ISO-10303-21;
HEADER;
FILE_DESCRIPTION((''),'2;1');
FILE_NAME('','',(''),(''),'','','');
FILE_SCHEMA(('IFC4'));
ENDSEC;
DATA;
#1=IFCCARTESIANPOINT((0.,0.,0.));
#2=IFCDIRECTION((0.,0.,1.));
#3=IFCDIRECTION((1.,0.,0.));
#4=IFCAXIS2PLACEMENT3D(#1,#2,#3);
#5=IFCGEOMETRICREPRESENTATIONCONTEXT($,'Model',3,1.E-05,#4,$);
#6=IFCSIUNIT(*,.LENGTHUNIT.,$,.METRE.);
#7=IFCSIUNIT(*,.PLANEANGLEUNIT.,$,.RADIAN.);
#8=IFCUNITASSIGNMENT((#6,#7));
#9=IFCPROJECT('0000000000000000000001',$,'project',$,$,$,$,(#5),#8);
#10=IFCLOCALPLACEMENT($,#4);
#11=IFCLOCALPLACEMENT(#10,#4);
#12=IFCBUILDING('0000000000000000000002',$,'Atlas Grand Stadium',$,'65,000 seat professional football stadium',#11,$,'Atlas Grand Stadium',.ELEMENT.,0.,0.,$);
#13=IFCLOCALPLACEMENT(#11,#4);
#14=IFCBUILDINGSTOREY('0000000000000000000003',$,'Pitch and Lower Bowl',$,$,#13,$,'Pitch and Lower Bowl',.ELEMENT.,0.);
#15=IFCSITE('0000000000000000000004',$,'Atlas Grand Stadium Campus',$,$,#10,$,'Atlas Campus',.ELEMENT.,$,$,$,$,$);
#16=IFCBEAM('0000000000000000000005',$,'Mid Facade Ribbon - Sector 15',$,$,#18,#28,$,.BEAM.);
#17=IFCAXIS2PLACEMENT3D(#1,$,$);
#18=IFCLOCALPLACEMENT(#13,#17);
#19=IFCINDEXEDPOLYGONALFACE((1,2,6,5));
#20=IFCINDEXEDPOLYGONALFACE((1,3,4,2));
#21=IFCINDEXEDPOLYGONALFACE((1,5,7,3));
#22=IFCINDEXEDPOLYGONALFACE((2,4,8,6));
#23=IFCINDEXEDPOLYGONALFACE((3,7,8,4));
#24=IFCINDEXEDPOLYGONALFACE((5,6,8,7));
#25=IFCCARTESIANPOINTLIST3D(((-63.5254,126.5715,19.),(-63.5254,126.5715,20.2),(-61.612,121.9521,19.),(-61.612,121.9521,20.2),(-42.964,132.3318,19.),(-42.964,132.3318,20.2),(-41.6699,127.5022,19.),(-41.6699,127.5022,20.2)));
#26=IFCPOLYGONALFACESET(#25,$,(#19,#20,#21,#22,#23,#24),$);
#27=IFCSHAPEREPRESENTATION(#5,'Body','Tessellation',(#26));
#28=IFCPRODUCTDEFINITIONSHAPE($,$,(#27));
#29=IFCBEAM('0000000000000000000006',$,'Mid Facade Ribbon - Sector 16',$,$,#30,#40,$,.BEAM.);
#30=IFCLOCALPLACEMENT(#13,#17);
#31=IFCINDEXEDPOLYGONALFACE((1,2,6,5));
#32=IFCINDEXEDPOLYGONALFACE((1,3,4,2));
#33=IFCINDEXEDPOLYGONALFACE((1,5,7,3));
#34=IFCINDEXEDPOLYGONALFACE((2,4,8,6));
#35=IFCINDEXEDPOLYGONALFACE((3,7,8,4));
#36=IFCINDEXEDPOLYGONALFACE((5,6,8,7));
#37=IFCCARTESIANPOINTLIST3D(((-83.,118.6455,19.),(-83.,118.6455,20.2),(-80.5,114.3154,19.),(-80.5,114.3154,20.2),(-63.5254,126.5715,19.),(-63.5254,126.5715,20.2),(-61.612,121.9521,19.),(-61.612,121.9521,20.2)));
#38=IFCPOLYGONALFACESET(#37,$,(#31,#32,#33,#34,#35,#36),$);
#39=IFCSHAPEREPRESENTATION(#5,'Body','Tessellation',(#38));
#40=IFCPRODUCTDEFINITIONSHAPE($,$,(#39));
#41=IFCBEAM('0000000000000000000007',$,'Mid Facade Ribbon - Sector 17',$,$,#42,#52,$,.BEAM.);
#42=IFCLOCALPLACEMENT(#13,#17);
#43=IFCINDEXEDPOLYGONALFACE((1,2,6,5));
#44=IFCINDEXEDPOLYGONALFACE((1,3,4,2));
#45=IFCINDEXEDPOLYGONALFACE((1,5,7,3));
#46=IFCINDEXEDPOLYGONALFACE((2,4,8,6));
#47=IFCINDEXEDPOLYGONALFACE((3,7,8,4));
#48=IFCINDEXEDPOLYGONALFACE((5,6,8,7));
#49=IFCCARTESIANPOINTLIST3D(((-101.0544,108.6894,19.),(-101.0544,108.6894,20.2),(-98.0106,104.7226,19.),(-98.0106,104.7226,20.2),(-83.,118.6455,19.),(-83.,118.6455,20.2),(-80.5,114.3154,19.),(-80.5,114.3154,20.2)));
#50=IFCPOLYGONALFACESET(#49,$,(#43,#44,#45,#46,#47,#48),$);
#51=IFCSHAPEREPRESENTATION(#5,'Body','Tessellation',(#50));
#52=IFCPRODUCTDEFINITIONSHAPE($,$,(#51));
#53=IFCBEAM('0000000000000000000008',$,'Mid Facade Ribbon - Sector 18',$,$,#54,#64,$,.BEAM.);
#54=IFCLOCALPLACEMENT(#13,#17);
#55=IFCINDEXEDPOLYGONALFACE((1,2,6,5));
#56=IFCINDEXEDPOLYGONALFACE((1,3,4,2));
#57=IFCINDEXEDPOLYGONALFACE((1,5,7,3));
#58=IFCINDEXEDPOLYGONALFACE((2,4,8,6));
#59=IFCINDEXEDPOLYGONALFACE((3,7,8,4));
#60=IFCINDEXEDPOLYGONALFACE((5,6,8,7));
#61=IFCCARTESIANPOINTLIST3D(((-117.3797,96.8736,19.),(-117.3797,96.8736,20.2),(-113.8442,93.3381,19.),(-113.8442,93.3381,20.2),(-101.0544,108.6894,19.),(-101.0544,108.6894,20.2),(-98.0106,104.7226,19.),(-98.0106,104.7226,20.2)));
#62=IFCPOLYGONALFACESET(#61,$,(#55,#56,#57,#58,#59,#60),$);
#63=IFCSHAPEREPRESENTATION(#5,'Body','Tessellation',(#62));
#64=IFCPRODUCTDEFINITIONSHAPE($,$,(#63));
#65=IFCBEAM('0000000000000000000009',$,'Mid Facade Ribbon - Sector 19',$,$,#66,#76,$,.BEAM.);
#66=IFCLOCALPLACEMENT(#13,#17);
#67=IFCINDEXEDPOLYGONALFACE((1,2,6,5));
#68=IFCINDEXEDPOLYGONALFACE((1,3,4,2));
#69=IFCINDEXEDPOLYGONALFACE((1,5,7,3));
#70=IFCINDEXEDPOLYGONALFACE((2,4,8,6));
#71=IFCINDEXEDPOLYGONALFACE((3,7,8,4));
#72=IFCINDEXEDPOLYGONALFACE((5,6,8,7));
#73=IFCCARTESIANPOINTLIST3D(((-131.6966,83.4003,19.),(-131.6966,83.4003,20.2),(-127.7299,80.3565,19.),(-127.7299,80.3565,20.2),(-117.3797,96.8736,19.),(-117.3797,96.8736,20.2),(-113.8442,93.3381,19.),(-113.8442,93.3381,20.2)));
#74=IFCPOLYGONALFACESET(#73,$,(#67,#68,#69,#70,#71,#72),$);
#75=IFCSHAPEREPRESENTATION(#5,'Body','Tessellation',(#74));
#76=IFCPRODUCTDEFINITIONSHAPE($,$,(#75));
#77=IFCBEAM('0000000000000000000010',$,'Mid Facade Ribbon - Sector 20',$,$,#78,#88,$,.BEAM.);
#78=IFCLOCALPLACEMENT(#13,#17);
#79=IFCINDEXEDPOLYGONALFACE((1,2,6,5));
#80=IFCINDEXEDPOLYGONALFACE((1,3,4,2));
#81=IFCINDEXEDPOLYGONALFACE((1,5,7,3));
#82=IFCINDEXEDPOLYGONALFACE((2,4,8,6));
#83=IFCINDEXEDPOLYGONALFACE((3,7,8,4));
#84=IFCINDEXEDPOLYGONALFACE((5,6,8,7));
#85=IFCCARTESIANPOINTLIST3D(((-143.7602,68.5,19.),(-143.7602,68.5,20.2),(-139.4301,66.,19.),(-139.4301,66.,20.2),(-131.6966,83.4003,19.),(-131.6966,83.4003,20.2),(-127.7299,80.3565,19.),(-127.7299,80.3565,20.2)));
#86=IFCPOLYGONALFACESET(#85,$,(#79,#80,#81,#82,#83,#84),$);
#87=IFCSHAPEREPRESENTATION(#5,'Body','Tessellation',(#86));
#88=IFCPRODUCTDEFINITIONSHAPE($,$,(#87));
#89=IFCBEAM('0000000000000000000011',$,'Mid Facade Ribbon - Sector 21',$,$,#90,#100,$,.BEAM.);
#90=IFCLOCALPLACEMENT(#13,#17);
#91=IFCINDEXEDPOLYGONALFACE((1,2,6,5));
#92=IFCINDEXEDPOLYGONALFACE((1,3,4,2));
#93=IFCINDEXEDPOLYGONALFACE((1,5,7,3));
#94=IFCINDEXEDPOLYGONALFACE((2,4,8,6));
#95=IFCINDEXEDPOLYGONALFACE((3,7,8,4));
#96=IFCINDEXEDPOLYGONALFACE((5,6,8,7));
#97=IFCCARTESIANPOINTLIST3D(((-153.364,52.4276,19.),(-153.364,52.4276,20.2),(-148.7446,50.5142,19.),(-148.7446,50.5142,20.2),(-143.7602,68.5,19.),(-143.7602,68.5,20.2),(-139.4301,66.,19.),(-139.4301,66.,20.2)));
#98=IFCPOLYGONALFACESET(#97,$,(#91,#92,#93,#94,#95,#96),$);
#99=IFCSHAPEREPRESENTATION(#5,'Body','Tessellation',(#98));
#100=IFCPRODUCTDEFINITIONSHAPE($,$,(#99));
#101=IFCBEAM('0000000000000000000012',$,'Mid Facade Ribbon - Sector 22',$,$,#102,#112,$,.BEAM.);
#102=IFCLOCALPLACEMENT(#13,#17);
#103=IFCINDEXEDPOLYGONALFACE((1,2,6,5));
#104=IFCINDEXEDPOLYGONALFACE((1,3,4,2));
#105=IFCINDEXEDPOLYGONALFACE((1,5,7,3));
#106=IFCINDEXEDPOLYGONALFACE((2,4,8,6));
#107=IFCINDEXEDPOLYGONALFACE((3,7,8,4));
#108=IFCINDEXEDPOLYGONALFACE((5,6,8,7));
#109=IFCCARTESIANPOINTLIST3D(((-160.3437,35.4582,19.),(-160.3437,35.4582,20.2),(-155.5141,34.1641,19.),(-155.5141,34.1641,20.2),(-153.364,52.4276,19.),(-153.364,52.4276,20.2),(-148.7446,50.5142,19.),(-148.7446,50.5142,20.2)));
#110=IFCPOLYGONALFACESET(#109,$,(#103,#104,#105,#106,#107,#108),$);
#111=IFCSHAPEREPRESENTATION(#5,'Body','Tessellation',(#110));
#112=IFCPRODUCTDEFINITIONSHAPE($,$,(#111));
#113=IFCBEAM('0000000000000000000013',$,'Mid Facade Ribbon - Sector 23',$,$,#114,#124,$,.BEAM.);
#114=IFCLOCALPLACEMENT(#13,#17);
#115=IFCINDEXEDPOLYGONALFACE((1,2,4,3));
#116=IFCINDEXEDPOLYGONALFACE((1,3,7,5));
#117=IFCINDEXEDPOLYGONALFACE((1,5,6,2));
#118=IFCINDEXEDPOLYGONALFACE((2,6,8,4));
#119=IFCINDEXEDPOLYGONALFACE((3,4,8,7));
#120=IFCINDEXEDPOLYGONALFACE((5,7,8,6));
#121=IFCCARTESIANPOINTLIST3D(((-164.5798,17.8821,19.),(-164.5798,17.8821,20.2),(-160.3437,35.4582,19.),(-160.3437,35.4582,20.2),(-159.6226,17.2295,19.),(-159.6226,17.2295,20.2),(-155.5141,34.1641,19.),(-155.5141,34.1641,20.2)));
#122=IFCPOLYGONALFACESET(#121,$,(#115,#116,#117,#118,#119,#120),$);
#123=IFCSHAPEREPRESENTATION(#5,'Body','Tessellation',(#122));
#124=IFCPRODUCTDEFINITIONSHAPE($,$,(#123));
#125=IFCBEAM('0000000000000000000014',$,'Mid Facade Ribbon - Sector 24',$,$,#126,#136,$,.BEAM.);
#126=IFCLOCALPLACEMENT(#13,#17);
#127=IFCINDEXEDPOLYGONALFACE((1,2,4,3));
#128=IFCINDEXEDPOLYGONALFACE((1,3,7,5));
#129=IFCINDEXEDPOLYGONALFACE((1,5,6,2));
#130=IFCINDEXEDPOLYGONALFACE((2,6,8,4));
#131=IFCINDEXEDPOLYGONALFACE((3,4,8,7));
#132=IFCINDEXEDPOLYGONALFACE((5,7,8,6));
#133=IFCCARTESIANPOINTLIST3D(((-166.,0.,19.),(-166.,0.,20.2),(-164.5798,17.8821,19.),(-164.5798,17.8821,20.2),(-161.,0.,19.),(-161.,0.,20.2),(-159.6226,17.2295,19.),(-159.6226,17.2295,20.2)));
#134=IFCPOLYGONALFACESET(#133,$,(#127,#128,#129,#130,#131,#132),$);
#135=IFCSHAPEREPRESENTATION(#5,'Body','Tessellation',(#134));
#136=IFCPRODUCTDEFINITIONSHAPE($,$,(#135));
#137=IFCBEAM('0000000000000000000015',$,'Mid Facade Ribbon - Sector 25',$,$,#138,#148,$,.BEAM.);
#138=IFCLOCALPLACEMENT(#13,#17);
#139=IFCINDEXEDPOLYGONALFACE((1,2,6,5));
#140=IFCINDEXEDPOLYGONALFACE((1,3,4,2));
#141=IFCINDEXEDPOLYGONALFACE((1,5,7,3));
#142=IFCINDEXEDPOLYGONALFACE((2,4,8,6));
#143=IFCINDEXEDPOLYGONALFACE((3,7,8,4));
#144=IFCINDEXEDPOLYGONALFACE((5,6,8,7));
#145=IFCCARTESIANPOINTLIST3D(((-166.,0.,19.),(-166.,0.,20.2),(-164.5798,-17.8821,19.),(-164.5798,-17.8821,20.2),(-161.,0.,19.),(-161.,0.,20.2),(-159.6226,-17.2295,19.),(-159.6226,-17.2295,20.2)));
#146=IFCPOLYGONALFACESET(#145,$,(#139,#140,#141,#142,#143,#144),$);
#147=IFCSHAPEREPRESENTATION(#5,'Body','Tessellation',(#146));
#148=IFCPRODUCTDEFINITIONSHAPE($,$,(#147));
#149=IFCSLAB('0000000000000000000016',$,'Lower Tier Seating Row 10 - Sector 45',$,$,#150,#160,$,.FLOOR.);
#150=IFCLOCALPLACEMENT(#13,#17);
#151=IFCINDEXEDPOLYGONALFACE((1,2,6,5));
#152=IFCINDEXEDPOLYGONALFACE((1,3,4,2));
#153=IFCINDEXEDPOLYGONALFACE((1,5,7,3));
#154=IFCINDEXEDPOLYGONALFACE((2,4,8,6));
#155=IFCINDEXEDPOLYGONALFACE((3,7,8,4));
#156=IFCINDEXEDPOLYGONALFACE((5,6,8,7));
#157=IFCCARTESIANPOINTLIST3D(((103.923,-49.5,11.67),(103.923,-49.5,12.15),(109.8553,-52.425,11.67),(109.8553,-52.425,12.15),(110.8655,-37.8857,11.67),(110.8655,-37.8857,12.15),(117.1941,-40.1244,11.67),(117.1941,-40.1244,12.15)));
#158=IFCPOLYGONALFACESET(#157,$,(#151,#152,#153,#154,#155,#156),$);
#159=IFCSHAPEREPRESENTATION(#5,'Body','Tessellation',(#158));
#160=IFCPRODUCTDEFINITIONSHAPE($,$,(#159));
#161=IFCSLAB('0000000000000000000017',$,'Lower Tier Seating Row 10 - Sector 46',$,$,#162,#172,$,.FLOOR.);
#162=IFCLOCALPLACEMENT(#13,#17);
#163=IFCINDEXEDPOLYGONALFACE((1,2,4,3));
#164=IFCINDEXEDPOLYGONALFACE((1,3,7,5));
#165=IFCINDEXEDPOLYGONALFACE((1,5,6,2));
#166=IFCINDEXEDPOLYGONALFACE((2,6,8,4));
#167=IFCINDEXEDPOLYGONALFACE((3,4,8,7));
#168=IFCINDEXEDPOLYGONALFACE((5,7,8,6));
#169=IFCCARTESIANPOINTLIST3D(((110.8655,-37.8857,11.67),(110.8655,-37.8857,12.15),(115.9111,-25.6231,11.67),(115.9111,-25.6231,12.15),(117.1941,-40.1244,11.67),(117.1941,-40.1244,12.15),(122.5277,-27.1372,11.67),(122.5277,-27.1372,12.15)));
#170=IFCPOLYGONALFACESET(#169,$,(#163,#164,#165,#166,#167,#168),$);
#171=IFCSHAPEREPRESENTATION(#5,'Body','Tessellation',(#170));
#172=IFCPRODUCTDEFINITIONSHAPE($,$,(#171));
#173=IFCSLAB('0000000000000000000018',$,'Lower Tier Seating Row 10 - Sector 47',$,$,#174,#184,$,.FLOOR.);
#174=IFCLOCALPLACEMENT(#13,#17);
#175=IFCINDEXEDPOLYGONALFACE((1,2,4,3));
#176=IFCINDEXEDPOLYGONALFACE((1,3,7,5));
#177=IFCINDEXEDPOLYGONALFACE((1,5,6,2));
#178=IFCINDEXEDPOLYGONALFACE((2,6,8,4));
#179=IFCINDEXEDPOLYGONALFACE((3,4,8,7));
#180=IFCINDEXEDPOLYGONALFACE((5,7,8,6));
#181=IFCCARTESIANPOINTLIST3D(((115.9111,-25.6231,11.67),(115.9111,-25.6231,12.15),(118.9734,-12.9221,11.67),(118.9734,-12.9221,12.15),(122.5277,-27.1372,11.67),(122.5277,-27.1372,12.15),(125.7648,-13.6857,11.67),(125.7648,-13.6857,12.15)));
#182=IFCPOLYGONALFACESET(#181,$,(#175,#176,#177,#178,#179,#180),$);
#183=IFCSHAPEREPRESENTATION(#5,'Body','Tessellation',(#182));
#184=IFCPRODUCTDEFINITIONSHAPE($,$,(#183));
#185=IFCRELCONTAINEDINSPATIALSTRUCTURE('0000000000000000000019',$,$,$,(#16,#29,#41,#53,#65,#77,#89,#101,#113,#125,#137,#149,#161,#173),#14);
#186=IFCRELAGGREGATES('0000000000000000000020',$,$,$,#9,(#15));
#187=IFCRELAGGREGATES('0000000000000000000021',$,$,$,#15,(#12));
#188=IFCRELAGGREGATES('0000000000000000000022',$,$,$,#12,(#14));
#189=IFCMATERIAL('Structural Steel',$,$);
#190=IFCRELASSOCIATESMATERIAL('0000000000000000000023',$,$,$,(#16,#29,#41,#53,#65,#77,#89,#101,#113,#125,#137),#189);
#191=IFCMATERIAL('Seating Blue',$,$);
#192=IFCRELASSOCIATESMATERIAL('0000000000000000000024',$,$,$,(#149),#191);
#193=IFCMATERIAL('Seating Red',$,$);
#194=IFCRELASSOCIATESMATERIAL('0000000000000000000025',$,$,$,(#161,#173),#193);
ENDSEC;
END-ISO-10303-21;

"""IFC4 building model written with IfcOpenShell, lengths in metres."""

from ifc_helpers import new_model, si_unit, frame, origin_with_axes, place, context, project, spatial, polyline, outline, extrude, material, element, save


model = new_model("IFC4")

# Units and contexts
model_context = context("Model", 3, precision=1e-05, world=origin_with_axes())
ifc_project = project(units=[si_unit("LENGTHUNIT", "METRE"), si_unit("PLANEANGLEUNIT", "RADIAN")], contexts=[model_context])

# Site, building, storey
site_placement = place(None, origin_with_axes())
site = spatial("IfcSite", under=ifc_project, at=site_placement, Name="Atlas Grand Stadium Campus", LongName="Atlas Campus", CompositionType="ELEMENT")
building_placement = place(site_placement, origin_with_axes())
building = spatial("IfcBuilding", under=site, at=building_placement, Name="Atlas Grand Stadium", ObjectType="65,000 seat professional football stadium", LongName="Atlas Grand Stadium", CompositionType="ELEMENT", ElevationOfRefHeight=0.0, ElevationOfTerrain=0.0)
storey_placement = place(building_placement, origin_with_axes())
storey = spatial("IfcBuildingStorey", under=building, at=storey_placement, Name="Pitch and Lower Bowl", LongName="Pitch and Lower Bowl", CompositionType="ELEMENT", Elevation=0.0)

# Beams
ifc_material_1 = material(Name="Structural Steel")
beam_1_placement = place(storey_placement, frame((0.0, 0.0, 19.0), z_axis=(0.0, 0.0, 1.0), x_axis=(1.0, 0.0, 0.0)))
element("IfcBeam", 1, at=beam_1_placement, inside=storey, material=ifc_material_1, Name="Mid Facade Ribbon - Sector 15", PredefinedType="BEAM", context=model_context, shape_type="SweptSolid", body=[
    extrude(outline(polyline([(-42.964, 132.3318), (-63.5254, 126.5715), (-61.612, 121.9521), (-41.6699, 127.5022), (-42.964, 132.3318)])), origin_with_axes(), (0.0, 0.0, 1.0), 1.2),
])
beam_2_placement = place(storey_placement, frame((0.0, 0.0, 19.0), z_axis=(0.0, 0.0, 1.0), x_axis=(1.0, 0.0, 0.0)))
element("IfcBeam", 2, at=beam_2_placement, inside=storey, material=ifc_material_1, Name="Mid Facade Ribbon - Sector 16", PredefinedType="BEAM", context=model_context, shape_type="SweptSolid", body=[
    extrude(outline(polyline([(-63.5254, 126.5715), (-83.0, 118.6455), (-80.5, 114.3153), (-61.612, 121.9521), (-63.5254, 126.5715)])), origin_with_axes(), (0.0, 0.0, 1.0), 1.2),
])
beam_3_placement = place(storey_placement, frame((0.0, 0.0, 19.0), z_axis=(0.0, 0.0, 1.0), x_axis=(1.0, 0.0, 0.0)))
element("IfcBeam", 3, at=beam_3_placement, inside=storey, material=ifc_material_1, Name="Mid Facade Ribbon - Sector 17", PredefinedType="BEAM", context=model_context, shape_type="SweptSolid", body=[
    extrude(outline(polyline([(-83.0, 118.6455), (-101.0544, 108.6894), (-98.0106, 104.7226), (-80.5, 114.3153), (-83.0, 118.6455)])), origin_with_axes(), (0.0, 0.0, 1.0), 1.2),
])
beam_4_placement = place(storey_placement, frame((0.0, 0.0, 19.0), z_axis=(0.0, 0.0, 1.0), x_axis=(1.0, 0.0, 0.0)))
element("IfcBeam", 4, at=beam_4_placement, inside=storey, material=ifc_material_1, Name="Mid Facade Ribbon - Sector 18", PredefinedType="BEAM", context=model_context, shape_type="SweptSolid", body=[
    extrude(outline(polyline([(-101.0544, 108.6894), (-117.3797, 96.8736), (-113.8442, 93.3381), (-98.0106, 104.7226), (-101.0544, 108.6894)])), origin_with_axes(), (0.0, 0.0, 1.0), 1.2),
])
beam_5_placement = place(storey_placement, frame((0.0, 0.0, 19.0), z_axis=(0.0, 0.0, 1.0), x_axis=(1.0, 0.0, 0.0)))
element("IfcBeam", 5, at=beam_5_placement, inside=storey, material=ifc_material_1, Name="Mid Facade Ribbon - Sector 19", PredefinedType="BEAM", context=model_context, shape_type="SweptSolid", body=[
    extrude(outline(polyline([(-117.3797, 96.8736), (-131.6967, 83.4003), (-127.7299, 80.3565), (-113.8442, 93.3381), (-117.3797, 96.8736)])), origin_with_axes(), (0.0, 0.0, 1.0), 1.2),
])
beam_6_placement = place(storey_placement, frame((0.0, 0.0, 19.0), z_axis=(0.0, 0.0, 1.0), x_axis=(1.0, 0.0, 0.0)))
element("IfcBeam", 6, at=beam_6_placement, inside=storey, material=ifc_material_1, Name="Mid Facade Ribbon - Sector 20", PredefinedType="BEAM", context=model_context, shape_type="SweptSolid", body=[
    extrude(outline(polyline([(-131.6967, 83.4003), (-143.7602, 68.5), (-139.4301, 66.0), (-127.7299, 80.3565), (-131.6967, 83.4003)])), origin_with_axes(), (0.0, 0.0, 1.0), 1.2),
])
beam_7_placement = place(storey_placement, frame((0.0, 0.0, 19.0), z_axis=(0.0, 0.0, 1.0), x_axis=(1.0, 0.0, 0.0)))
element("IfcBeam", 7, at=beam_7_placement, inside=storey, material=ifc_material_1, Name="Mid Facade Ribbon - Sector 21", PredefinedType="BEAM", context=model_context, shape_type="SweptSolid", body=[
    extrude(outline(polyline([(-143.7602, 68.5), (-153.364, 52.4276), (-148.7446, 50.5142), (-139.4301, 66.0), (-143.7602, 68.5)])), origin_with_axes(), (0.0, 0.0, 1.0), 1.2),
])
beam_8_placement = place(storey_placement, frame((0.0, 0.0, 19.0), z_axis=(0.0, 0.0, 1.0), x_axis=(1.0, 0.0, 0.0)))
element("IfcBeam", 8, at=beam_8_placement, inside=storey, material=ifc_material_1, Name="Mid Facade Ribbon - Sector 22", PredefinedType="BEAM", context=model_context, shape_type="SweptSolid", body=[
    extrude(outline(polyline([(-153.364, 52.4276), (-160.3437, 35.4582), (-155.5141, 34.1641), (-148.7446, 50.5142), (-153.364, 52.4276)])), origin_with_axes(), (0.0, 0.0, 1.0), 1.2),
])
beam_9_placement = place(storey_placement, frame((0.0, 0.0, 19.0), z_axis=(0.0, 0.0, 1.0), x_axis=(1.0, 0.0, 0.0)))
element("IfcBeam", 9, at=beam_9_placement, inside=storey, material=ifc_material_1, Name="Mid Facade Ribbon - Sector 23", PredefinedType="BEAM", context=model_context, shape_type="SweptSolid", body=[
    extrude(outline(polyline([(-160.3437, 35.4582), (-164.5798, 17.8821), (-159.6226, 17.2295), (-155.5141, 34.1641), (-160.3437, 35.4582)])), origin_with_axes(), (0.0, 0.0, 1.0), 1.2),
])
beam_10_placement = place(storey_placement, frame((0.0, 0.0, 19.0), z_axis=(0.0, 0.0, 1.0), x_axis=(1.0, 0.0, 0.0)))
element("IfcBeam", 10, at=beam_10_placement, inside=storey, material=ifc_material_1, Name="Mid Facade Ribbon - Sector 24", PredefinedType="BEAM", context=model_context, shape_type="SweptSolid", body=[
    extrude(outline(polyline([(-164.5798, 17.8821), (-166.0, 0.0), (-161.0, 0.0), (-159.6226, 17.2295), (-164.5798, 17.8821)])), origin_with_axes(), (0.0, 0.0, 1.0), 1.2),
])
beam_11_placement = place(storey_placement, frame((0.0, 0.0, 19.0), z_axis=(0.0, 0.0, 1.0), x_axis=(1.0, 0.0, 0.0)))
element("IfcBeam", 11, at=beam_11_placement, inside=storey, material=ifc_material_1, Name="Mid Facade Ribbon - Sector 25", PredefinedType="BEAM", context=model_context, shape_type="SweptSolid", body=[
    extrude(outline(polyline([(-166.0, 0.0), (-164.5798, -17.8821), (-159.6226, -17.2295), (-161.0, 0.0), (-166.0, 0.0)])), origin_with_axes(), (0.0, 0.0, 1.0), 1.2),
])

# Slabs
ifc_material_2 = material(Name="Seating Blue")
slab_1_placement = place(storey_placement, frame((0.0, 0.0, 11.67), z_axis=(0.0, 0.0, 1.0), x_axis=(1.0, 0.0, 0.0)))
element("IfcSlab", 12, at=slab_1_placement, inside=storey, material=ifc_material_2, Name="Lower Tier Seating Row 10 - Sector 45", PredefinedType="FLOOR", context=model_context, shape_type="SweptSolid", body=[
    extrude(outline(polyline([(109.8553, -52.425), (117.1941, -40.1244), (110.8655, -37.8857), (103.9231, -49.5), (109.8553, -52.425)])), origin_with_axes(), (0.0, 0.0, 1.0), 0.48),
])
ifc_material_3 = material(Name="Seating Red")
slab_2_placement = place(storey_placement, frame((0.0, 0.0, 11.67), z_axis=(0.0, 0.0, 1.0), x_axis=(1.0, 0.0, 0.0)))
element("IfcSlab", 13, at=slab_2_placement, inside=storey, material=ifc_material_3, Name="Lower Tier Seating Row 10 - Sector 46", PredefinedType="FLOOR", context=model_context, shape_type="SweptSolid", body=[
    extrude(outline(polyline([(117.1941, -40.1244), (122.5277, -27.1372), (115.9111, -25.6231), (110.8655, -37.8857), (117.1941, -40.1244)])), origin_with_axes(), (0.0, 0.0, 1.0), 0.48),
])
slab_3_placement = place(storey_placement, frame((0.0, 0.0, 11.67), z_axis=(0.0, 0.0, 1.0), x_axis=(1.0, 0.0, 0.0)))
element("IfcSlab", 14, at=slab_3_placement, inside=storey, material=ifc_material_3, Name="Lower Tier Seating Row 10 - Sector 47", PredefinedType="FLOOR", context=model_context, shape_type="SweptSolid", body=[
    extrude(outline(polyline([(122.5277, -27.1372), (125.7648, -13.6857), (118.9734, -12.9221), (115.9111, -25.6231), (122.5277, -27.1372)])), origin_with_axes(), (0.0, 0.0, 1.0), 0.48),
])

save(model, "model.ifc")
